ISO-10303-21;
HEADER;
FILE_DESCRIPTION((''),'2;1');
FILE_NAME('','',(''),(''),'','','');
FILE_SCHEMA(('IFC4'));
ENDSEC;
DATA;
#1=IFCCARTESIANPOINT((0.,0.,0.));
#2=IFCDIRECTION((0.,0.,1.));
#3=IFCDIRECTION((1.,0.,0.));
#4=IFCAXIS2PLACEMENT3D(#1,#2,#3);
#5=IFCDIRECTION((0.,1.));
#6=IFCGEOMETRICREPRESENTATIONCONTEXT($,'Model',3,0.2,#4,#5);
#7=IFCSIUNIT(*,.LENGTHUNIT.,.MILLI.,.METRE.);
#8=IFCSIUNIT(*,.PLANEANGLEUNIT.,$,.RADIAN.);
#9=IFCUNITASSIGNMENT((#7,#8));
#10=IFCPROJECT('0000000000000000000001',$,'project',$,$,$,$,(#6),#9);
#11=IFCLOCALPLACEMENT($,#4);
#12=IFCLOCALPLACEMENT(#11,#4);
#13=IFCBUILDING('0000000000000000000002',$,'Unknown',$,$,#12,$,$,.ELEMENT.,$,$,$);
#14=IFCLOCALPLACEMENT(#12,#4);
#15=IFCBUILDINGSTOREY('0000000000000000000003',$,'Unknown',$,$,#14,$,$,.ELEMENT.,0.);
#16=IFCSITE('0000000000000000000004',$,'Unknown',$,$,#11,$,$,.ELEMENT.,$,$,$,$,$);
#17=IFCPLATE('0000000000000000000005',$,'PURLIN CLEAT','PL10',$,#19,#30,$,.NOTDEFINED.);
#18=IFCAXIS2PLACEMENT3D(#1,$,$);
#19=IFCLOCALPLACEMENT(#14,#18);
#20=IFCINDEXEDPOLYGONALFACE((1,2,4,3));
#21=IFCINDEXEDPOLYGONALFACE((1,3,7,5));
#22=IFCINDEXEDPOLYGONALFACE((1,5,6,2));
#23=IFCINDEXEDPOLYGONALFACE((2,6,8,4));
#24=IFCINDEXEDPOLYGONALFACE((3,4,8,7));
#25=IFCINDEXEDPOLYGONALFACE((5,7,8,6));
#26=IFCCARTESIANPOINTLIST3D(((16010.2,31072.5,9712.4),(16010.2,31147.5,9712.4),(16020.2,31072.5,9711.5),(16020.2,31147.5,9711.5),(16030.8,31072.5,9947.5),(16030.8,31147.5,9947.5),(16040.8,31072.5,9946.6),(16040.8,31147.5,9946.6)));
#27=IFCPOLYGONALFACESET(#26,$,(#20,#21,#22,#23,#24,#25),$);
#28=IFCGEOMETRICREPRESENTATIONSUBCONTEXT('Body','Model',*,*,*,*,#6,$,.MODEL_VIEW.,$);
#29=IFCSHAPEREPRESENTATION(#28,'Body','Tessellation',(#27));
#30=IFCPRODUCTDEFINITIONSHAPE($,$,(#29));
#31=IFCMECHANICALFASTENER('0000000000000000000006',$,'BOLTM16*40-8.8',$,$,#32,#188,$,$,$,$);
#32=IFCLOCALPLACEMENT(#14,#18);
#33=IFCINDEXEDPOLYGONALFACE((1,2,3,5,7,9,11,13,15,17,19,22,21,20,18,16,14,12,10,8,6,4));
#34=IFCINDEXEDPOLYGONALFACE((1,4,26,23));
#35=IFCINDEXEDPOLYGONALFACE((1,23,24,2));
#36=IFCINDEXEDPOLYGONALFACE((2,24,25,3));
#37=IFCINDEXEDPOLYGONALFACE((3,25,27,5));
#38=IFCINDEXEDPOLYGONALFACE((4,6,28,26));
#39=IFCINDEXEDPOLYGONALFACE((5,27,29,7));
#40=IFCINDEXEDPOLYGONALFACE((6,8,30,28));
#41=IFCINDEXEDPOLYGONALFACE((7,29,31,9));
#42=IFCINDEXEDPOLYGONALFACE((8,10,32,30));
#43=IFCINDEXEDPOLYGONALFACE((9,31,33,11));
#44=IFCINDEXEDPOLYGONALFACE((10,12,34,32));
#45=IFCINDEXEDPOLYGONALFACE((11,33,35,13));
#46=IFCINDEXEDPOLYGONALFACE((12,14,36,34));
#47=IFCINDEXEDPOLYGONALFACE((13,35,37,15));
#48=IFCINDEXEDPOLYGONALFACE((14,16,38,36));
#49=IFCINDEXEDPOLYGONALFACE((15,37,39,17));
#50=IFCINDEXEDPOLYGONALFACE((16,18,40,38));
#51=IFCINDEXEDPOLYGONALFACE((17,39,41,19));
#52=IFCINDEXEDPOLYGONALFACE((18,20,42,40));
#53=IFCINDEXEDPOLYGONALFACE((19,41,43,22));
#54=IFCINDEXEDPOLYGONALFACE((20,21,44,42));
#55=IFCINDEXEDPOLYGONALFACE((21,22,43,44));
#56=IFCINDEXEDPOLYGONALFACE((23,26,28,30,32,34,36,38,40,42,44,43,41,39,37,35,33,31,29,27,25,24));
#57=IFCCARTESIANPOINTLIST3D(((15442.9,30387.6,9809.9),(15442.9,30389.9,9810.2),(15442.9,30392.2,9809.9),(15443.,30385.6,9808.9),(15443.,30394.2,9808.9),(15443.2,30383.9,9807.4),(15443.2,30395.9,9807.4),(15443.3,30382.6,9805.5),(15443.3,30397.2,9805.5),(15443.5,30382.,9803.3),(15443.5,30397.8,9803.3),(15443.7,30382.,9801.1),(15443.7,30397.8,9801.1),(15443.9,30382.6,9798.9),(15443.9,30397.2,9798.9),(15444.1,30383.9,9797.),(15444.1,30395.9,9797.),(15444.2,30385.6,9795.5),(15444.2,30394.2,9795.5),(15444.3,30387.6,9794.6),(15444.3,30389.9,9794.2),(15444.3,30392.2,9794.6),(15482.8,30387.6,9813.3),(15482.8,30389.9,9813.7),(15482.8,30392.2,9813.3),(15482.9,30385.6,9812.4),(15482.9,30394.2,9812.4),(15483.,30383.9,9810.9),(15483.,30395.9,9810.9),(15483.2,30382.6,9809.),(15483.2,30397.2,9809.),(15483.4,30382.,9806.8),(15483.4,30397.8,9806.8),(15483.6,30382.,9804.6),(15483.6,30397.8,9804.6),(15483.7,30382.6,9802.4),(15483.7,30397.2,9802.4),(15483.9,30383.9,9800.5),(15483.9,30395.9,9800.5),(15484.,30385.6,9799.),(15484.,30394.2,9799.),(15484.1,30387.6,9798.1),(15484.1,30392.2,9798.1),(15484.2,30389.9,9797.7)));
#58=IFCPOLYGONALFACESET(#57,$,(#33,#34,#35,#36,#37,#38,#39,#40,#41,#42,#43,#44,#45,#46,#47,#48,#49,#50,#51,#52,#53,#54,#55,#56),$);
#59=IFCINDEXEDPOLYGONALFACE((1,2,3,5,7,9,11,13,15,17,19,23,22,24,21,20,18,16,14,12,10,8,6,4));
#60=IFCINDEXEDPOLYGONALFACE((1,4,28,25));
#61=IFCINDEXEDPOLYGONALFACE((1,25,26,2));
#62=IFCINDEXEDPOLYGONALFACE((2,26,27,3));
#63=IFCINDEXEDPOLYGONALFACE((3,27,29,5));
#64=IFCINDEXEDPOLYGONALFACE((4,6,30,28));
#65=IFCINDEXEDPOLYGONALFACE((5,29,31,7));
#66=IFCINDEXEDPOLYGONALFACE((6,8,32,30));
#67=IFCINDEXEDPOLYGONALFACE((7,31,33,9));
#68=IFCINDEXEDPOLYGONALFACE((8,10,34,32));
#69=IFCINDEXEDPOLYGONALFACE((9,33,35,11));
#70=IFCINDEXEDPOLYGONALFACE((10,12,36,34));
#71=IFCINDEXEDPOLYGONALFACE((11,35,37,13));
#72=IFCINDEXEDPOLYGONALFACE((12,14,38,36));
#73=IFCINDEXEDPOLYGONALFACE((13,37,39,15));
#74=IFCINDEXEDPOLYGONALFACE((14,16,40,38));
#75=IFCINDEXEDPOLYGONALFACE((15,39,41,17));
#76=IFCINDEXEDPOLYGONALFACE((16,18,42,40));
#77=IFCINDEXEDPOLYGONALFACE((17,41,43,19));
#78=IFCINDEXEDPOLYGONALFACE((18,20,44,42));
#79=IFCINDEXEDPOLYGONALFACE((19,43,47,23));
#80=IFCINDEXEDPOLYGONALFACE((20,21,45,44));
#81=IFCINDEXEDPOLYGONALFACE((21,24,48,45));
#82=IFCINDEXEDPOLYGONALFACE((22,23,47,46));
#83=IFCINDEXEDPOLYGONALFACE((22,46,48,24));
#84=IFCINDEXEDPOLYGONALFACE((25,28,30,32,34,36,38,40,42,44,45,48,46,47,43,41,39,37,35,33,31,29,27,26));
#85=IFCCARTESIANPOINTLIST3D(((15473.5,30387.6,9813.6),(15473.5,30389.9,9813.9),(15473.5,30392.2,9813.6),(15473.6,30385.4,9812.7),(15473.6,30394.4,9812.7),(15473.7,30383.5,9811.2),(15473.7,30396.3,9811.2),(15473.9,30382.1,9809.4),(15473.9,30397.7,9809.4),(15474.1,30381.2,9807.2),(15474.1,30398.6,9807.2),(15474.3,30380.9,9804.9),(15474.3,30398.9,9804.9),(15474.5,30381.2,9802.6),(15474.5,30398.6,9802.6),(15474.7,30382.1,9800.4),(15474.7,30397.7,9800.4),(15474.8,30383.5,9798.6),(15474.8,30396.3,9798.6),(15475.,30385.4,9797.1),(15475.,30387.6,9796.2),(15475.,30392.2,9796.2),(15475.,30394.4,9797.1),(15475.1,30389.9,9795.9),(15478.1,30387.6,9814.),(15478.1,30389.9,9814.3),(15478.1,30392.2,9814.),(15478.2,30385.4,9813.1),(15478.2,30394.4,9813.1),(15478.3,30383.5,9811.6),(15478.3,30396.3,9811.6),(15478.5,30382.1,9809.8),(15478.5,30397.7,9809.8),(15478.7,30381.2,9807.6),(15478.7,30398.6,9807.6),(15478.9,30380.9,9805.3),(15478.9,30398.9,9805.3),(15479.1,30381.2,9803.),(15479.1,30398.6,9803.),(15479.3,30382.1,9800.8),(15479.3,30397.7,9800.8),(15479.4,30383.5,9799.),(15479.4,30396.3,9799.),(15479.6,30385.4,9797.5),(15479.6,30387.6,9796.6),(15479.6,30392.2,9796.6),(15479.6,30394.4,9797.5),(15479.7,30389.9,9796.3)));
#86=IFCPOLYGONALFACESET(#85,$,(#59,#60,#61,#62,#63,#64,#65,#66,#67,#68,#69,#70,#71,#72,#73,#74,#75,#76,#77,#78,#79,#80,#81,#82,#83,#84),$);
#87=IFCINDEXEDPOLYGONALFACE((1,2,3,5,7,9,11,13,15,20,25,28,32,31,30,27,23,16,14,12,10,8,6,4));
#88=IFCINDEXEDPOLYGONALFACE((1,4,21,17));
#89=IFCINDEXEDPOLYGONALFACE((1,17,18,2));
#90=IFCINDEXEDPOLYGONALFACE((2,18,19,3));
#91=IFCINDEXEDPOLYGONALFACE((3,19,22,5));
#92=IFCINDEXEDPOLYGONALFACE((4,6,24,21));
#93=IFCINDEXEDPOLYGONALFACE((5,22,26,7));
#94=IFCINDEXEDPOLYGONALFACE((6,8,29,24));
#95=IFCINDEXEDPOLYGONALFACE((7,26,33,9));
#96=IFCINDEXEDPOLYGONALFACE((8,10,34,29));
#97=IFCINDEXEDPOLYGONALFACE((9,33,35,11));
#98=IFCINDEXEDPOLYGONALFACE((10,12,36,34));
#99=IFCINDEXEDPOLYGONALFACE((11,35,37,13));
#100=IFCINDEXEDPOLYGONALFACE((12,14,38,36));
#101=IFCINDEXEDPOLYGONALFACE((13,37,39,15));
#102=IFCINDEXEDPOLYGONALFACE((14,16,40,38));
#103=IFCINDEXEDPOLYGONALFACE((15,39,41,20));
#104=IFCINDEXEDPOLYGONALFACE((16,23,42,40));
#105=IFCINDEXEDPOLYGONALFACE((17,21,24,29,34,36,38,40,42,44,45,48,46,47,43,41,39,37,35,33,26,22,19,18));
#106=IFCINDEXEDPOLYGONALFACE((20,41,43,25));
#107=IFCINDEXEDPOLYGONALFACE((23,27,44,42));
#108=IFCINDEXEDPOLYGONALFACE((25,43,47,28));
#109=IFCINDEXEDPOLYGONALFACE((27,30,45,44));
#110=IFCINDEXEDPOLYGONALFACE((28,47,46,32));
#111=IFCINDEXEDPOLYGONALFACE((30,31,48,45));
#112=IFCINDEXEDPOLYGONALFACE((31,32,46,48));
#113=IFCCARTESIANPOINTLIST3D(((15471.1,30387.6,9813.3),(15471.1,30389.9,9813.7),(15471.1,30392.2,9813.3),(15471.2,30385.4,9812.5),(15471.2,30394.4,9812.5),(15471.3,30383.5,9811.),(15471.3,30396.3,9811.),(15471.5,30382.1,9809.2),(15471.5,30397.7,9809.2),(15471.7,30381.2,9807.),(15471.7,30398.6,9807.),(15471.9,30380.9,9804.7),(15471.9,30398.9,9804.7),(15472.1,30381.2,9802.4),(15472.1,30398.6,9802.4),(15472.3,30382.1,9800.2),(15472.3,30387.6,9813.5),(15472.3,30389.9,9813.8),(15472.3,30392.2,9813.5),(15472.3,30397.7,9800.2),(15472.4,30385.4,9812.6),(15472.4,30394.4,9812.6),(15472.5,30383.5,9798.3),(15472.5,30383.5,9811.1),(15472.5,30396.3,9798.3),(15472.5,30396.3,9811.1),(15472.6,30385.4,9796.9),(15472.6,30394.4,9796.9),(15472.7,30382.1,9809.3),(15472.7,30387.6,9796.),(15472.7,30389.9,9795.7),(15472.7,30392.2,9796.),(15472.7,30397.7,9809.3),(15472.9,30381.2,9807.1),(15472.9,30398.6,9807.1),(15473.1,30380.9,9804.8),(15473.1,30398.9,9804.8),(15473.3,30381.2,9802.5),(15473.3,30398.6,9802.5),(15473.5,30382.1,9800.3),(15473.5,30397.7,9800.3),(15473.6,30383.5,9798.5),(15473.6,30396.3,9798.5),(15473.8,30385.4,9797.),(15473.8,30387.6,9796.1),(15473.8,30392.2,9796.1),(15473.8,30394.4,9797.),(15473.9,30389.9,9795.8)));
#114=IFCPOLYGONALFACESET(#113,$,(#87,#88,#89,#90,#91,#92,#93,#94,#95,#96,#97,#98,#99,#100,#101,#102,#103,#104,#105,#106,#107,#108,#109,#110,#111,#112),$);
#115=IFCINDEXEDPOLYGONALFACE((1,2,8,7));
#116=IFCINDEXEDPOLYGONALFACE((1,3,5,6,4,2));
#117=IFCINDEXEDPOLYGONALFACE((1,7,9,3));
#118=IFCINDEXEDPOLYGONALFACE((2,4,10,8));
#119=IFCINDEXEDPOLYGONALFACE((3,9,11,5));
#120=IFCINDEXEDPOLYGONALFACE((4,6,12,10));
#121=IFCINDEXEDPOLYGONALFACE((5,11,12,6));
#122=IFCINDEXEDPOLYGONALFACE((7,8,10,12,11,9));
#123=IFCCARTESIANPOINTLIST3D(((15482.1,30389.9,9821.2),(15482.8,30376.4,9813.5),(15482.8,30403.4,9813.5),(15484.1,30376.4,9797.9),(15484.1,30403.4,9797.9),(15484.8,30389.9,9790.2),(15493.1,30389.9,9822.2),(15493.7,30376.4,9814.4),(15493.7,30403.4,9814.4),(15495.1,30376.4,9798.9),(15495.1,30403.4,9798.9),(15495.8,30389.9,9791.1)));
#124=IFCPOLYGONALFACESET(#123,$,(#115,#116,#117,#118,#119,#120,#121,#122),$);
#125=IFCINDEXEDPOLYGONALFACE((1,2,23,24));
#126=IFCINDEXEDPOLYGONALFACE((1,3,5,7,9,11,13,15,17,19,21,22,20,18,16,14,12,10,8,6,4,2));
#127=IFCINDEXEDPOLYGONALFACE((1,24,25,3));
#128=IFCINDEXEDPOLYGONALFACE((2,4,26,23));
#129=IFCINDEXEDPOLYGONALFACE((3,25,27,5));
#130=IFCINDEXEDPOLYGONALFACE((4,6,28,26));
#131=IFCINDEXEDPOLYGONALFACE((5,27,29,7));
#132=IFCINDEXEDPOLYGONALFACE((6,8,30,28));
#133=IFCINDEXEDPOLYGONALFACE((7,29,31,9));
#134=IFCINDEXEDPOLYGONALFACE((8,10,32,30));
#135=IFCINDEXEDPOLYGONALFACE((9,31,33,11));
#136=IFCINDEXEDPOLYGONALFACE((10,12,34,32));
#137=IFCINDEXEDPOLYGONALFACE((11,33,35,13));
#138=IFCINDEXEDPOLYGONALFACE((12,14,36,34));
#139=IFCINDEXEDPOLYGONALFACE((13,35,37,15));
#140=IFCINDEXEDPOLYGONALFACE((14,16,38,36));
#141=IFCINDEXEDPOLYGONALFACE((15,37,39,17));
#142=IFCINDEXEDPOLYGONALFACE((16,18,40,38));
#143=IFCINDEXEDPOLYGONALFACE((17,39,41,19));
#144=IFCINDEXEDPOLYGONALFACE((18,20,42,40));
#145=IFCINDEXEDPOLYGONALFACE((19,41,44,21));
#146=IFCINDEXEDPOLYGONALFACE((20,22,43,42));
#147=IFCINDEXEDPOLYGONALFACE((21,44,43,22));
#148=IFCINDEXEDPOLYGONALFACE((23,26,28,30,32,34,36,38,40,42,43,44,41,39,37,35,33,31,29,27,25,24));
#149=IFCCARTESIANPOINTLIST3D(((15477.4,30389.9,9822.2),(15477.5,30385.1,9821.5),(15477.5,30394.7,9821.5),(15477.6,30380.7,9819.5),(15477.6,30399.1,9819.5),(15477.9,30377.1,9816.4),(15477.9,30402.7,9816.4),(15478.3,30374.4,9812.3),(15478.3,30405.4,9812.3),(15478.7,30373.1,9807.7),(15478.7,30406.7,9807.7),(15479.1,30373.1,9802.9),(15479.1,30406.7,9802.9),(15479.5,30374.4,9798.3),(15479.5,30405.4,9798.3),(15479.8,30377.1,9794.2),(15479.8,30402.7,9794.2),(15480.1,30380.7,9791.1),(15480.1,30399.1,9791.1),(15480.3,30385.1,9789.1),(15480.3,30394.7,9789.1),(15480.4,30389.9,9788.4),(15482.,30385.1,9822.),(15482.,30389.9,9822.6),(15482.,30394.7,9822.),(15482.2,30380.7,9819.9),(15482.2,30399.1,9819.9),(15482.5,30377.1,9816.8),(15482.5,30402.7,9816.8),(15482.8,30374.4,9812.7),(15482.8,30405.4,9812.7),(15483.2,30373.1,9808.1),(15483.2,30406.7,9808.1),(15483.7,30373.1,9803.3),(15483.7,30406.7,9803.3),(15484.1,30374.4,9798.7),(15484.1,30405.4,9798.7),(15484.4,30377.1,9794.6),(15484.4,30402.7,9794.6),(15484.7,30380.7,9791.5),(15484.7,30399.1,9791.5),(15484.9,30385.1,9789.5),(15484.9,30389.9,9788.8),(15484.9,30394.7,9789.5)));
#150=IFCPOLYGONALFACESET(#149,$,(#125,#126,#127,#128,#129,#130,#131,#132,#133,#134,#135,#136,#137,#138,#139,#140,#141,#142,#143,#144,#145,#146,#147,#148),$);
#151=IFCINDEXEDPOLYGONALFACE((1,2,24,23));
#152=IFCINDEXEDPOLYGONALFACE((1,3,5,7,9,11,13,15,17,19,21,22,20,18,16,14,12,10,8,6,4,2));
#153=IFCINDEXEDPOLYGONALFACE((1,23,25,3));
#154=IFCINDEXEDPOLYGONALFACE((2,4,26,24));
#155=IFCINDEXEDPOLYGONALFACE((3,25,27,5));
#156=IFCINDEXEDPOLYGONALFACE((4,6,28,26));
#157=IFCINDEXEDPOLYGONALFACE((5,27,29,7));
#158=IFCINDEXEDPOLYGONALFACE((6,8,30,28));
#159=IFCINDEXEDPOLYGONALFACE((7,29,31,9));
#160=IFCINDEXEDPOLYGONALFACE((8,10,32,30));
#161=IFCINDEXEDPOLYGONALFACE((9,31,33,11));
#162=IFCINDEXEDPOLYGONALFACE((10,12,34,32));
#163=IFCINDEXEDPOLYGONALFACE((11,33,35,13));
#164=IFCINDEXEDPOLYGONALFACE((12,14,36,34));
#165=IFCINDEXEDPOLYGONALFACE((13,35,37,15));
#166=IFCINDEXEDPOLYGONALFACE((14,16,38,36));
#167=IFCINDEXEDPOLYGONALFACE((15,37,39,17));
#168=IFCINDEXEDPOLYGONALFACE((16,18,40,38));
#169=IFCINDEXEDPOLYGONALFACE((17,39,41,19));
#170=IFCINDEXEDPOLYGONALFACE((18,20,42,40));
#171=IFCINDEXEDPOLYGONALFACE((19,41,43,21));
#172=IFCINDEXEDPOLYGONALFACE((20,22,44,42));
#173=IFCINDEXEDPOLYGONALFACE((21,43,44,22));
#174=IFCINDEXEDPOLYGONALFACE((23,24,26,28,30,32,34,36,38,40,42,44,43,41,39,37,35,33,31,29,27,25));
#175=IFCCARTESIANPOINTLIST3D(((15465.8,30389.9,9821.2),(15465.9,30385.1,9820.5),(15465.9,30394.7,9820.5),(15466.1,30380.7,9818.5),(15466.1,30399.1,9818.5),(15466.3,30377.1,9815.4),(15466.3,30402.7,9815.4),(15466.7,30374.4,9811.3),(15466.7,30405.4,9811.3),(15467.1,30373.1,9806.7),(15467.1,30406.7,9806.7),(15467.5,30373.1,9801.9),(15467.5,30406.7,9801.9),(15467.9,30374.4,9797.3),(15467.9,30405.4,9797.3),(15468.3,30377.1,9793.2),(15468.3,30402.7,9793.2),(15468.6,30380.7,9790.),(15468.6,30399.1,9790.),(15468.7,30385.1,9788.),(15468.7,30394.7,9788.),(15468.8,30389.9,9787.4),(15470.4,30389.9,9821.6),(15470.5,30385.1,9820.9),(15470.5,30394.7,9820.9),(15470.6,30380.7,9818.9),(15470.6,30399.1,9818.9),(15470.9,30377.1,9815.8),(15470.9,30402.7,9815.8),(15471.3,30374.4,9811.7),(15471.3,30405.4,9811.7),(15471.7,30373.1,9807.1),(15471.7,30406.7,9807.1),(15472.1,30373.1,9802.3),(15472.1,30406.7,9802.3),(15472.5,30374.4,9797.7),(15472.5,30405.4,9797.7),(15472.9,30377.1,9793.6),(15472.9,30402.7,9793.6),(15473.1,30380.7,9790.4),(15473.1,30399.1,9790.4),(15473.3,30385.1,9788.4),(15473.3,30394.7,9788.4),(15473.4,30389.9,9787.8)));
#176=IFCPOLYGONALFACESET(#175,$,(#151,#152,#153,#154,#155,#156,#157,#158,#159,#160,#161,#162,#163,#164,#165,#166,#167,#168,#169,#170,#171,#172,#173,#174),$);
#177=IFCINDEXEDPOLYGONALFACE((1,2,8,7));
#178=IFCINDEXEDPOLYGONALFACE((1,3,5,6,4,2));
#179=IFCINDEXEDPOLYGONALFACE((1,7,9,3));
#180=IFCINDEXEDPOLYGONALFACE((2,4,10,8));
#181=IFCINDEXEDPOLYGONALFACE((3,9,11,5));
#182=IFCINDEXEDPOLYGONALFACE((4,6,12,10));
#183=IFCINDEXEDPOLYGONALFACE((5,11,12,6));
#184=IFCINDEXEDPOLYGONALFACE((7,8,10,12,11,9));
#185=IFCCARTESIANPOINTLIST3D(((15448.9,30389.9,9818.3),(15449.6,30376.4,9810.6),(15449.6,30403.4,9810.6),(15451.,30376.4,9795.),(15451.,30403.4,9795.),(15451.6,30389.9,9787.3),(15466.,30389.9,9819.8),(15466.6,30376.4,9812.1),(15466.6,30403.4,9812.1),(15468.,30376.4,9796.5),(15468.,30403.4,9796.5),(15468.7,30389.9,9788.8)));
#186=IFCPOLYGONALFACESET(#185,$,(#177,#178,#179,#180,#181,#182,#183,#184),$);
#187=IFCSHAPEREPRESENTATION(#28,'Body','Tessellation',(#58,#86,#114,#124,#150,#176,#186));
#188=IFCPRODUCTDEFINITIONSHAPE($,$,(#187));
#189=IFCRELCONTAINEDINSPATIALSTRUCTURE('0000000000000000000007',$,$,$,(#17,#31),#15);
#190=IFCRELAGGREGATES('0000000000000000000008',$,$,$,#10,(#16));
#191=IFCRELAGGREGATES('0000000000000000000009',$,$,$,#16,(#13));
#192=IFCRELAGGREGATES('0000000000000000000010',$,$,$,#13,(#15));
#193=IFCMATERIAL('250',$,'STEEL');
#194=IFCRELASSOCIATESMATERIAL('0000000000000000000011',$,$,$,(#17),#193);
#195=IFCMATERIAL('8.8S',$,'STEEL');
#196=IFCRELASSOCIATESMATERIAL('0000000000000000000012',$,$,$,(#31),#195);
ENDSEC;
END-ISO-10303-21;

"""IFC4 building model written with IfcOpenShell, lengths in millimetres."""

from ifc_helpers import new_model, si_unit, direction, frame, origin_with_axes, place, context, subcontext, project, spatial, line, arc, indexed_curve, outline, extrude, source, transform, mapped, material, element, save


model = new_model("IFC4")

# Units and contexts
model_context = context("Model", 3, precision=0.2, world=origin_with_axes(), true_north=direction((0.0, 1.0)))
body_context = subcontext(model_context, "Body", "Model", "MODEL_VIEW")
ifc_project = project(units=[si_unit("LENGTHUNIT", "METRE", prefix="MILLI"), si_unit("PLANEANGLEUNIT", "RADIAN")], contexts=[model_context])

# Site, building, storey
site_placement = place(None, origin_with_axes())
site = spatial("IfcSite", under=ifc_project, at=site_placement, Name="Unknown", CompositionType="ELEMENT")
building_placement = place(site_placement, origin_with_axes())
building = spatial("IfcBuilding", under=site, at=building_placement, Name="Unknown", CompositionType="ELEMENT")
storey_placement = place(building_placement, origin_with_axes())
storey = spatial("IfcBuildingStorey", under=building, at=storey_placement, Name="Unknown", CompositionType="ELEMENT", Elevation=0.0)

# Plate
ifc_material_1 = material(Name="250", Category="STEEL")
plate_placement = place(storey_placement, frame((16015.2, 31072.5, 9711.9), z_axis=(0.996195, 0.0, -0.087156), x_axis=(0.0, 1.0, 0.0)))
element("IfcPlate", 1, at=plate_placement, inside=storey, material=ifc_material_1, Name="PURLIN CLEAT", Description="PL10", PredefinedType="NOTDEFINED", context=body_context, shape_type="SolidModel", body=[
    extrude(outline(indexed_curve([(0.0, 0.0), (75.0, 0.0), (75.0, 236.0), (0.0, 236.0)], segments=[line(1, 2, 3, 4, 1)])), frame((0.0, 0.0, 5.0), z_axis=(0.0, 0.0, 1.0), x_axis=(1.0, 0.0, 0.0)), (0.0, 0.0, -1.0), 10.0),
])

# Mechanical fastener
ifc_material_2 = material(Name="8.8S", Category="STEEL")
shared_shape_1 = source(origin_with_axes(), body_context, "Body", "SweptSolid", [
    extrude(outline(indexed_curve([(8.0, 0.0), (0.0, 8.0), (-8.0, 0.0), (0.0, -8.0)], segments=[arc(1, 2, 3), arc(3, 4, 1)])), frame((0.0, 0.0, 9.2), z_axis=(0.0, 0.0, -1.0), x_axis=(0.0, 1.0, 0.0)), (0.0, 0.0, 1.0), 40.0),
    extrude(outline(indexed_curve([(0.0, 9.0), (6.4, 6.4), (9.0, 0.0), (6.4, -6.4), (0.0, -9.0), (-0.8, -9.0), (-9.0, 0.0), (-6.4, 6.4)], segments=[arc(1, 2, 3), arc(3, 4, 5), arc(5, 6, 7), arc(7, 8, 1)])), frame((0.0, 0.0, 4.6), z_axis=(0.0, 0.0, -1.0), x_axis=(0.0, 1.0, 0.0)), (0.0, 0.0, 1.0), 4.6),
    extrude(outline(indexed_curve([(0.0, 9.0), (6.4, 6.4), (9.0, 0.0), (6.4, -6.4), (0.0, -9.0), (-0.8, -9.0), (-9.0, 0.0), (-6.4, 6.4)], segments=[arc(1, 2, 3), arc(3, 4, 5), arc(5, 6, 7), arc(7, 8, 1)])), frame((0.0, 0.0, -1.2), z_axis=(0.0, 0.0, -1.0), x_axis=(0.0, 1.0, 0.0)), (0.0, 0.0, 1.0), 1.2),
    extrude(outline(indexed_curve([(15.6, 0.0), (7.8, 13.5), (-7.8, 13.5), (-15.6, 0.0), (-7.8, -13.5), (7.8, -13.5)], segments=[line(1, 2, 3, 4, 5, 6, 1)])), frame((0.0, 0.0, 20.2), z_axis=(0.0, 0.0, -1.0), x_axis=(0.0, 1.0, 0.0)), (0.0, 0.0, 1.0), 11.0),
    extrude(outline(indexed_curve([(17.0, 0.0), (0.0, 17.0), (-17.0, 0.0), (0.0, -17.0)], segments=[arc(1, 2, 3), arc(3, 4, 1)])), frame((0.0, 0.0, 9.2), z_axis=(0.0, 0.0, -1.0), x_axis=(0.0, 1.0, 0.0)), (0.0, 0.0, 1.0), 4.6),
    extrude(outline(indexed_curve([(17.0, 0.0), (0.0, 17.0), (-17.0, 0.0), (0.0, -17.0)], segments=[arc(1, 2, 3), arc(3, 4, 1)])), frame((0.0, 0.0, -2.4), z_axis=(0.0, 0.0, -1.0), x_axis=(0.0, 1.0, 0.0)), (0.0, 0.0, 1.0), 4.6),
    extrude(outline(indexed_curve([(15.6, 0.0), (7.8, 13.5), (-7.8, 13.5), (-15.6, 0.0), (-7.8, -13.5), (7.8, -13.5)], segments=[line(1, 2, 3, 4, 5, 6, 1)])), frame((0.0, 0.0, -7.0), z_axis=(0.0, 0.0, -1.0), x_axis=(0.0, 1.0, 0.0)), (0.0, 0.0, 1.0), 17.1),
])
mechanical_fastener_1_placement = place(storey_placement, frame((15474.3, 30389.9, 9804.9), z_axis=(0.996195, 0.0, 0.087156), x_axis=(0.0, 1.0, 0.0)))
element("IfcMechanicalFastener", 2, at=mechanical_fastener_1_placement, inside=storey, material=ifc_material_2, Name="BOLTM16*40-8.8", context=body_context, shape_type="MappedRepresentation", body=[
    mapped(shared_shape_1, transform((0.0, 0.0, 0.0))),
])

save(model, "model.ifc")
